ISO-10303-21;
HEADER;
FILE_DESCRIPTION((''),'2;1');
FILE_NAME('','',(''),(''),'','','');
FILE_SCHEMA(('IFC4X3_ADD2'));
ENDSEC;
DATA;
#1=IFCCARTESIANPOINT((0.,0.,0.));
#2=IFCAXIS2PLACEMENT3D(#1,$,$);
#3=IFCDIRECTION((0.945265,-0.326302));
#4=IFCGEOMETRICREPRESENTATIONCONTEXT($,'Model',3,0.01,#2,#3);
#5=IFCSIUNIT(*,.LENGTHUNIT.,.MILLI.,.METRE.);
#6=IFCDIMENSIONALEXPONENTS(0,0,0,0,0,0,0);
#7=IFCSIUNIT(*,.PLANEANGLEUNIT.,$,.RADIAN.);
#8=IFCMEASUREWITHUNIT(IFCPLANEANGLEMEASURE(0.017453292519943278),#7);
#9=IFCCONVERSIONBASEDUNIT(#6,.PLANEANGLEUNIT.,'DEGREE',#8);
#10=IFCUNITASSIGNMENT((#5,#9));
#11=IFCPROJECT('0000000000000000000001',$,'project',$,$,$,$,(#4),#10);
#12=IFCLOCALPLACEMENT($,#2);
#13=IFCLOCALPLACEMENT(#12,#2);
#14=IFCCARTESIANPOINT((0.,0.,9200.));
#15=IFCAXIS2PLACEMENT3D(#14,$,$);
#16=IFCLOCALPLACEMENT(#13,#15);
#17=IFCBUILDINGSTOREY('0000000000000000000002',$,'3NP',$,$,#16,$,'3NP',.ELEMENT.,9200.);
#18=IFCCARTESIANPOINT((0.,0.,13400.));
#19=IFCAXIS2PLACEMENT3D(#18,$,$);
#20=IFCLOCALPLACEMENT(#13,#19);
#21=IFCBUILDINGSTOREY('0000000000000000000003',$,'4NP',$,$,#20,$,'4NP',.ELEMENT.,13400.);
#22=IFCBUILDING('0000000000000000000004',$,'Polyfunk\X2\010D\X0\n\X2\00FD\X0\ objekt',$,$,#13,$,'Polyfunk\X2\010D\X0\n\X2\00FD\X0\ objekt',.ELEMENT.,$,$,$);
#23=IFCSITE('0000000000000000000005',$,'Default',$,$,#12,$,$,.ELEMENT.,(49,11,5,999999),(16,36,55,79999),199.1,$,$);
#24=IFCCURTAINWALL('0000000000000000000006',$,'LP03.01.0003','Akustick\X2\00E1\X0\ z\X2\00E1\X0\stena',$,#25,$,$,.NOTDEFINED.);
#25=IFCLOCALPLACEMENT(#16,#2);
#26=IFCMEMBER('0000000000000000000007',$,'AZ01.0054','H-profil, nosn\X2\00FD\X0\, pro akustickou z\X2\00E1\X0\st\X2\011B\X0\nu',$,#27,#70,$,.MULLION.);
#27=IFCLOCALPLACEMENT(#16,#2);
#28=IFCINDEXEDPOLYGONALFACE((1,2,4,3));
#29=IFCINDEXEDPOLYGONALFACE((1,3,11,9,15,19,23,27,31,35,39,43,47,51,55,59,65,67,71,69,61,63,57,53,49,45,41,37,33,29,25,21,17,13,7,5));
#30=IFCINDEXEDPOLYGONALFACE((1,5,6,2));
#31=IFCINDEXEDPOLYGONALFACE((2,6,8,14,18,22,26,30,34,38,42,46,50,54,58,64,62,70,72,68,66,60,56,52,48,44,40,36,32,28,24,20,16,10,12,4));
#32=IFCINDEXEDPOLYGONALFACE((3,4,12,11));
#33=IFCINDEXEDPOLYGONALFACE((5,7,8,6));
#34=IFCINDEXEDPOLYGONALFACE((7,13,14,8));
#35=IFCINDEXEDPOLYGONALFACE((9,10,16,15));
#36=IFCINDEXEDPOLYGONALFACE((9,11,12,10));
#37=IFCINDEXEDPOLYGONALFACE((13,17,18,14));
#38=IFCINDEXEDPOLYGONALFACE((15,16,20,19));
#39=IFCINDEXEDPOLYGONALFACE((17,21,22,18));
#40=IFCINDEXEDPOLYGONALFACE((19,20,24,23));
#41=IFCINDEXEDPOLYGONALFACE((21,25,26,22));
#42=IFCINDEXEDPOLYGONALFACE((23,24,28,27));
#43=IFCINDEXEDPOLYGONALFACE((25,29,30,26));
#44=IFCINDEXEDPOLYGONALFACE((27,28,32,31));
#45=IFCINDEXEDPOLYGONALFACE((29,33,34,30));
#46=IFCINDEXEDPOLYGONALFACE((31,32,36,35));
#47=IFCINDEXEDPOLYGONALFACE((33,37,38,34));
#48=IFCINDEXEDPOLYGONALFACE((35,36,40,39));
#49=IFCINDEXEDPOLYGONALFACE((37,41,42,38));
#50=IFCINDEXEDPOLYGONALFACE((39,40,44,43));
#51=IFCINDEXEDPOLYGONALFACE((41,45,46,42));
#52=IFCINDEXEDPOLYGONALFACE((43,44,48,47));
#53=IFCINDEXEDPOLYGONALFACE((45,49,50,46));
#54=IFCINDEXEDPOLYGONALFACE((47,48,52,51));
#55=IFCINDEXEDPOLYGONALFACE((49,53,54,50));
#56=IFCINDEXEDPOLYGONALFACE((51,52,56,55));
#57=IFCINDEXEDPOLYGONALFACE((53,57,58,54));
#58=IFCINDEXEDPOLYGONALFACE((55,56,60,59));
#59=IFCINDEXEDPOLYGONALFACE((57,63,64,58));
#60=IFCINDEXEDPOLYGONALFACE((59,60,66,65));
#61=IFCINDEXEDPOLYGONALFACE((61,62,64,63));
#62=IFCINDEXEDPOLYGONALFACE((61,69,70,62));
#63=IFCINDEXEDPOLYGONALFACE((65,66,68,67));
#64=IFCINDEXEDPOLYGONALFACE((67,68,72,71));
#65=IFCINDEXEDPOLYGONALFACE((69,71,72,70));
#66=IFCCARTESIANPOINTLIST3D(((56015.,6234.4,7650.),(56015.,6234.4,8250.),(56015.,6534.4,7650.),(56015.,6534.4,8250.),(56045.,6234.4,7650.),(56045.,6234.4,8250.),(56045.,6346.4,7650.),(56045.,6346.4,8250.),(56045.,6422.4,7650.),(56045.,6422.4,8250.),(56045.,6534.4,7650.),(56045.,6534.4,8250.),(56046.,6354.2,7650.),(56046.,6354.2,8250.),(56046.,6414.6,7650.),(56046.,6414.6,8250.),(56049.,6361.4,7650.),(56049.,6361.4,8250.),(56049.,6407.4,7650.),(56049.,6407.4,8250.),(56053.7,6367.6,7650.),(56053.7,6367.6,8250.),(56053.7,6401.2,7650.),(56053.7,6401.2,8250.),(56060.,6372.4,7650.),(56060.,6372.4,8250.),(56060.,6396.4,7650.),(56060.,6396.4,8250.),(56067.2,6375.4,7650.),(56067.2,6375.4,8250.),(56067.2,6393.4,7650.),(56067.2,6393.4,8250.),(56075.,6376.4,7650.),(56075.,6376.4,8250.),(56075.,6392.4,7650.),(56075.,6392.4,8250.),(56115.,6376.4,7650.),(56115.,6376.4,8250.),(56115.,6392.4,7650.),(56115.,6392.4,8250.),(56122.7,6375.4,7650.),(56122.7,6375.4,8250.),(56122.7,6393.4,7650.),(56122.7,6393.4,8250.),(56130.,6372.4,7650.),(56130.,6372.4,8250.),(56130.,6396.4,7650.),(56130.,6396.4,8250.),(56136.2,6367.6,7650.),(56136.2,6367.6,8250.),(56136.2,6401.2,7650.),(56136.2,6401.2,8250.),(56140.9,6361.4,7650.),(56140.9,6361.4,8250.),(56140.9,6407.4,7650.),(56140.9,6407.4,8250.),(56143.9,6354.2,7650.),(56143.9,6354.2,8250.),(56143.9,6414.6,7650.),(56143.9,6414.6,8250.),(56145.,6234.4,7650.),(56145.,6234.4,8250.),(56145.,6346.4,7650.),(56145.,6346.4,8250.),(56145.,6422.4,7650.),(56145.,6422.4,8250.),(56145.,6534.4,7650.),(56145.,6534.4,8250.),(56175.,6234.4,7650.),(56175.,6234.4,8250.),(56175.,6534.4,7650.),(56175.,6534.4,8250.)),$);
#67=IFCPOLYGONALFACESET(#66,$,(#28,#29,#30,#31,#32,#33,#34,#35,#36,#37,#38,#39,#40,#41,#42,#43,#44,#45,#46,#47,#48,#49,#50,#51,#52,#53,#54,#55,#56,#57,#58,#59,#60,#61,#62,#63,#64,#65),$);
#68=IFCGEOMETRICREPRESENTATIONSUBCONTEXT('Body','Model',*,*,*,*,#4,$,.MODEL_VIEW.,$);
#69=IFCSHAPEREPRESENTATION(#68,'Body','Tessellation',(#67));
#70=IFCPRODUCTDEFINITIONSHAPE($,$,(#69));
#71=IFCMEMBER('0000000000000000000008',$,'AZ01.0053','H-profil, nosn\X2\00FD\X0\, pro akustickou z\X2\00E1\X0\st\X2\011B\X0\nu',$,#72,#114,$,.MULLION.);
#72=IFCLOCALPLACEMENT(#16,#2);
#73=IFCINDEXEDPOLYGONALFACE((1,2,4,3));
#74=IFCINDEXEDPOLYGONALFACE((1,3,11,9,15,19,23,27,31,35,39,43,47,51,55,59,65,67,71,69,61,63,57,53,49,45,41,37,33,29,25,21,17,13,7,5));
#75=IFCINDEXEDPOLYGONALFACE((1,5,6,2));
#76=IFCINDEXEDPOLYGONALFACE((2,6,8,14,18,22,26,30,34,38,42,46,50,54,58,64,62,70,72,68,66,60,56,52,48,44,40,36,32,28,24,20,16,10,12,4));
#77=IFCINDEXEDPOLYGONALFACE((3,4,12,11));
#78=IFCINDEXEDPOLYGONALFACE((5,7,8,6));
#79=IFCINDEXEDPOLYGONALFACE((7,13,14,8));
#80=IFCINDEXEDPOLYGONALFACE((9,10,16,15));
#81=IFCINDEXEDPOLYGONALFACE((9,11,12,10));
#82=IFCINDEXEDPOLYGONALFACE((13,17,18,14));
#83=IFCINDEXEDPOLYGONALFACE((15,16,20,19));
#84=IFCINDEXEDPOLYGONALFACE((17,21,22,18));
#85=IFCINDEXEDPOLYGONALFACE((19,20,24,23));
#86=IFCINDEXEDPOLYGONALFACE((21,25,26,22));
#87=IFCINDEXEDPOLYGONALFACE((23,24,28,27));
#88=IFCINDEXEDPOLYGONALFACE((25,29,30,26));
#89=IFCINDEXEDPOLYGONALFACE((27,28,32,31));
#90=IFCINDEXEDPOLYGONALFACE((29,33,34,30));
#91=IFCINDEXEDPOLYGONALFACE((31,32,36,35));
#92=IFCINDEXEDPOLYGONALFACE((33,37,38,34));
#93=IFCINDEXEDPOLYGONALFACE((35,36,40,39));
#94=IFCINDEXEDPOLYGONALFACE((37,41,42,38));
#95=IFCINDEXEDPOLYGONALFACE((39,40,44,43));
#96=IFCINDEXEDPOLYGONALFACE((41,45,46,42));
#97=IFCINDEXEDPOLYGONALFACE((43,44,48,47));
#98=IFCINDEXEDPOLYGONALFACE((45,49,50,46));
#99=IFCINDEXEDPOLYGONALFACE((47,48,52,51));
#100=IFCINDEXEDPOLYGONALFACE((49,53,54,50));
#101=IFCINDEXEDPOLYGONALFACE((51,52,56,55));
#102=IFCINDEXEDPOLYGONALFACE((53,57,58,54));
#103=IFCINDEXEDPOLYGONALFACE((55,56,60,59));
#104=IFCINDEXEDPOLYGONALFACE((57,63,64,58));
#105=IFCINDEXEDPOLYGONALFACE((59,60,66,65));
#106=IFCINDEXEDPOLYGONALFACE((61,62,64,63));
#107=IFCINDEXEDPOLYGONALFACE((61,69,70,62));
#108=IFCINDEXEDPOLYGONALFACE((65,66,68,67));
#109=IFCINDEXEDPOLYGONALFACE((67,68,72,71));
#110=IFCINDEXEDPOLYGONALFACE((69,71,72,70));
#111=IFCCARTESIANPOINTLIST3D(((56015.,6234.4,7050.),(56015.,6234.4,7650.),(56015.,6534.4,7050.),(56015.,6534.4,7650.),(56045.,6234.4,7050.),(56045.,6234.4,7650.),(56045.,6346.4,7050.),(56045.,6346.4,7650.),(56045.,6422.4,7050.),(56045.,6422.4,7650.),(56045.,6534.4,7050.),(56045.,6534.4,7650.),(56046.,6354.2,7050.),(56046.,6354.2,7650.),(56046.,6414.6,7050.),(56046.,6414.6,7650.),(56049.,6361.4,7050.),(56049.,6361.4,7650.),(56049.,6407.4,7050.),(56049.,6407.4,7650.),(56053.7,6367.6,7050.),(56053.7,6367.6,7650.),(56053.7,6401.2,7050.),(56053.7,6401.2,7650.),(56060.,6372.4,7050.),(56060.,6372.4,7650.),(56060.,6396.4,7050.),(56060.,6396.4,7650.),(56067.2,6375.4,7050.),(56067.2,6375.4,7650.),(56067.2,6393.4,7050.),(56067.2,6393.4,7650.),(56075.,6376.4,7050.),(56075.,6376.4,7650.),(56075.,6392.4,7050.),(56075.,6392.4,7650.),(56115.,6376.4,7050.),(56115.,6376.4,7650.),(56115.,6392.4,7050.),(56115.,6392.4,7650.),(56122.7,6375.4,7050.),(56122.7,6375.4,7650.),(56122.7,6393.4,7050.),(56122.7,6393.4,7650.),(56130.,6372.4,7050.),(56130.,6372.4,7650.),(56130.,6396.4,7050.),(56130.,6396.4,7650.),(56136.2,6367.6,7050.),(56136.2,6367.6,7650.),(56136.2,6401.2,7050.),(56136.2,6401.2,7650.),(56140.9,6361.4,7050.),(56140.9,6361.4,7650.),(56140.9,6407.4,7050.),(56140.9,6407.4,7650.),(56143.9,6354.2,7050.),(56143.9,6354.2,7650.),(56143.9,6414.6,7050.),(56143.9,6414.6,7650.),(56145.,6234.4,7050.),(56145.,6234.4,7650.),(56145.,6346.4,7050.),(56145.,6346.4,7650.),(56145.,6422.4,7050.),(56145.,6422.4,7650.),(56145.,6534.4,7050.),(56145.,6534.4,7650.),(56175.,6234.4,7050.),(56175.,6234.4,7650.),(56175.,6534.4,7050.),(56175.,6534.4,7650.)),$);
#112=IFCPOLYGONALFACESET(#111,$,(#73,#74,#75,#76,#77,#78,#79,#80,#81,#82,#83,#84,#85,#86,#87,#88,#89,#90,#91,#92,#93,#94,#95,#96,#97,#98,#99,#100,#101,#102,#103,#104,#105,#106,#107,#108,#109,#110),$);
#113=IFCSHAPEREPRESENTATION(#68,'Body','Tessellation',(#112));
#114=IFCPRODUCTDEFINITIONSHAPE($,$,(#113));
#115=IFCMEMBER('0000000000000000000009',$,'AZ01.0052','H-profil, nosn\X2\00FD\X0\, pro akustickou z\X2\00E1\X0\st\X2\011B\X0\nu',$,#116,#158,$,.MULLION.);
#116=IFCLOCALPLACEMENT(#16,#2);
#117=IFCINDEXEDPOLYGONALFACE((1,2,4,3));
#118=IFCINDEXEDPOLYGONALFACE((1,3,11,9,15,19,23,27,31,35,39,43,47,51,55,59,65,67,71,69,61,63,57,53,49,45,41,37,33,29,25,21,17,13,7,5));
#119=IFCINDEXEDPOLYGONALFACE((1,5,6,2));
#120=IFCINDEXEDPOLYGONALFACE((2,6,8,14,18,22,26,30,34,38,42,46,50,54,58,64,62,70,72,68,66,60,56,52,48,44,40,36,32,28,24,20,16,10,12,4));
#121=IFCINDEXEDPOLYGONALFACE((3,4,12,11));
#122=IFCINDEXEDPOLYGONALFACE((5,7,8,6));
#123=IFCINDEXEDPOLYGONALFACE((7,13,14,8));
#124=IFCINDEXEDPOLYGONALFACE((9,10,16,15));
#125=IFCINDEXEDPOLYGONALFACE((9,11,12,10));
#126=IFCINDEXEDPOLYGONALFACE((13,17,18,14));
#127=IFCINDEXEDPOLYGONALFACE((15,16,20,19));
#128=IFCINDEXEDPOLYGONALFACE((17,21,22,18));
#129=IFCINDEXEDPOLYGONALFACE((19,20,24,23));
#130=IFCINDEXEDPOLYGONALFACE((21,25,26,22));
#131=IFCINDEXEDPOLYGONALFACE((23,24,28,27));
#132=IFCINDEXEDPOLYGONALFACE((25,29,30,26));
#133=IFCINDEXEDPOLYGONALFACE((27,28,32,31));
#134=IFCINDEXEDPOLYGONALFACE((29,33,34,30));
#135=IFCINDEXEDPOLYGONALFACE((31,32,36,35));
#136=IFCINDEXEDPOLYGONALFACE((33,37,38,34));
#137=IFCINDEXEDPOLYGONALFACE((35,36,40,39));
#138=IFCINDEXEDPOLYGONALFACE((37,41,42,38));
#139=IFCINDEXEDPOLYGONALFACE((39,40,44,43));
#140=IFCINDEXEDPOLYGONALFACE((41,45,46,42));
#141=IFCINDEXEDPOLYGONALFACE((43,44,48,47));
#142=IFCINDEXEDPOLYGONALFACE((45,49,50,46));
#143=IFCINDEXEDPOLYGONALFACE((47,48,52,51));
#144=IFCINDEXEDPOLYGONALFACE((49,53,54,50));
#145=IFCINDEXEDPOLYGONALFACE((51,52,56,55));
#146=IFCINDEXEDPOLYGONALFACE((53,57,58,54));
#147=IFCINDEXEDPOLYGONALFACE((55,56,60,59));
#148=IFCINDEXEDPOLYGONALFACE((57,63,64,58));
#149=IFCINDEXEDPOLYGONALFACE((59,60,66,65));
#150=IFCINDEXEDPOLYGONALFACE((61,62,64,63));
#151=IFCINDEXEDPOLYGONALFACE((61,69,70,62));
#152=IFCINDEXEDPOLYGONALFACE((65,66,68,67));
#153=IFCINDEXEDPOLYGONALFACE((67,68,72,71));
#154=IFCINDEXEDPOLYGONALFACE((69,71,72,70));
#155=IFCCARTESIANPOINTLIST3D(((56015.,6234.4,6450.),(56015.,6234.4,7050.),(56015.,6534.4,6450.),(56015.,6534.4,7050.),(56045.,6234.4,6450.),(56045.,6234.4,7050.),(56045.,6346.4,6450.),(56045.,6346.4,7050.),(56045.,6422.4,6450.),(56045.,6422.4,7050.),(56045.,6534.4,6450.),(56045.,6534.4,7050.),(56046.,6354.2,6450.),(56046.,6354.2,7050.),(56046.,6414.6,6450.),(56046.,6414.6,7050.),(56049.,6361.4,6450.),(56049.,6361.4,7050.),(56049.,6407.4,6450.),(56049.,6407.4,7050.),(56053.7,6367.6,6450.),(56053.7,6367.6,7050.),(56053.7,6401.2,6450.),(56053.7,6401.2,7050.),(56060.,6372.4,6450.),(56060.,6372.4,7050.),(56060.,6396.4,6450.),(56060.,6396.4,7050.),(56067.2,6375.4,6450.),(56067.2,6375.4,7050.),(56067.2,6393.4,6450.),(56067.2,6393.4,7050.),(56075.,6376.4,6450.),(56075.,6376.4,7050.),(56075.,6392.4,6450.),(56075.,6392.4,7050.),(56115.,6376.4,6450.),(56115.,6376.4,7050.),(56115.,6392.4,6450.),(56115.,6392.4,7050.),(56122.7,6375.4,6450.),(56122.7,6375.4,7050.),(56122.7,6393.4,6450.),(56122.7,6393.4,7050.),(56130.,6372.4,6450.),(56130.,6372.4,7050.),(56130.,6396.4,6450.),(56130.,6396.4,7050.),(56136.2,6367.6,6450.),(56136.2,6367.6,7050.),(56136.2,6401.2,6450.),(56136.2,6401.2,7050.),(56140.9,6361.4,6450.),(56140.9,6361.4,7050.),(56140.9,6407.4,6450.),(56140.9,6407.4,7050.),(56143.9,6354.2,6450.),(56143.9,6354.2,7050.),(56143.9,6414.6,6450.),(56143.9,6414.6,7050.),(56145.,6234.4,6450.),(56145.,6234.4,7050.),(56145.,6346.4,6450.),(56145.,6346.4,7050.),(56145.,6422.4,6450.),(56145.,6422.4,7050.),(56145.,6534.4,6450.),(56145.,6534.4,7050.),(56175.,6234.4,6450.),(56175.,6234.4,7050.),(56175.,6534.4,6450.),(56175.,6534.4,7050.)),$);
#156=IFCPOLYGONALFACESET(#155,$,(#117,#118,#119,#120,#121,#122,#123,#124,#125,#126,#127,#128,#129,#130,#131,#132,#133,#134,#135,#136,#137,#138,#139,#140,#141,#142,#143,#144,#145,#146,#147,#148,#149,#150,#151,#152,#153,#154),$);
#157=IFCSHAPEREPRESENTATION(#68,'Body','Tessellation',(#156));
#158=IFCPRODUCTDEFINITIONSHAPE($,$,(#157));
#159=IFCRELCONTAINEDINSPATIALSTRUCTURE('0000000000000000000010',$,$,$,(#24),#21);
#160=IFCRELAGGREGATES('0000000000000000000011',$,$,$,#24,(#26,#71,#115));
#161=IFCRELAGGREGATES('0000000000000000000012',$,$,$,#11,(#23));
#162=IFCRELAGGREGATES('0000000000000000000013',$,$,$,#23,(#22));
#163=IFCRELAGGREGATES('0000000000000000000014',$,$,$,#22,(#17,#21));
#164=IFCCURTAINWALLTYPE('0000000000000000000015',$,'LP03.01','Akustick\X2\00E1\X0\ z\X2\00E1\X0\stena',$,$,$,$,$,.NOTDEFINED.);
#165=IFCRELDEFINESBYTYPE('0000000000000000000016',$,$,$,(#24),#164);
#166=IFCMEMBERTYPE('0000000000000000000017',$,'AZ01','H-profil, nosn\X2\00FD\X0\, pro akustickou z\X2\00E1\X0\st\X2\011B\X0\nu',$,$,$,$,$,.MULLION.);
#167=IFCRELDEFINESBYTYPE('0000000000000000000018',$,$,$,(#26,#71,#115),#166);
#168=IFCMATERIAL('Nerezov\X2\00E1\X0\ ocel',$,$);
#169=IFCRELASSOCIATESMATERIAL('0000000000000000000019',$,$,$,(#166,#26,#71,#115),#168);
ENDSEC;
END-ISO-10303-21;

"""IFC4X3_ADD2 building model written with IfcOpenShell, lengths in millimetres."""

from ifc_helpers import new_model, entity, si_unit, converted_unit, direction, frame, frame_2d, origin, place, context, subcontext, project, spatial, polyline, circle_curve, parameter, trimmed, segment, composite_curve, outline, extrude, source, transform, mapped, material, material_profile, profile_set, profile_usage, type_object, element, aggregate, save


model = new_model("IFC4X3_ADD2")

# Units and contexts
model_context = context("Model", 3, precision=0.01, world=origin(), true_north=direction((0.945265, -0.326302)))
body_context = subcontext(model_context, "Body", "Model", "MODEL_VIEW")
ifc_project = project(units=[si_unit("LENGTHUNIT", "METRE", prefix="MILLI"), converted_unit("PLANEANGLEUNIT", "DEGREE", entity("IfcPlaneAngleMeasure", 0.017453292519943278), si_unit("PLANEANGLEUNIT", "RADIAN"), dimensions=[0, 0, 0, 0, 0, 0, 0])], contexts=[model_context])

# Site, building, storey
site_placement = place(None, origin())
site = spatial("IfcSite", under=ifc_project, at=site_placement, Name="Default", CompositionType="ELEMENT", RefLatitude=(49, 11, 5, 999999), RefLongitude=(16, 36, 55, 79999), RefElevation=199.1)
building_placement = place(site_placement, origin())
building = spatial("IfcBuilding", under=site, at=building_placement, Name="Polyfunkčný objekt", LongName="Polyfunkčný objekt", CompositionType="ELEMENT")
storey_1_placement = place(building_placement, frame((0.0, 0.0, 9200.0)))
storey_1 = spatial("IfcBuildingStorey", under=building, at=storey_1_placement, Name="3NP", LongName="3NP", CompositionType="ELEMENT", Elevation=9200.0)

# Shared definitions
storey_2_placement = place(building_placement, frame((0.0, 0.0, 13400.0)))
storey_2 = spatial("IfcBuildingStorey", under=building, at=storey_2_placement, Name="4NP", LongName="4NP", CompositionType="ELEMENT", Elevation=13400.0)

# Shared definitions
curtain_wall_type_1 = type_object("IfcCurtainWallType", Name="LP03.01", Description="Akustická zástena", PredefinedType="NOTDEFINED")
ifc_material_1 = material(Name="Nerezová ocel")
ifc_material_profile_1 = material_profile(ifc_material_1, outline(composite_curve([segment(polyline([(50.0, -150.0), (80.0, -150.0)]), True, "CONTINUOUS"), segment(polyline([(80.0, -150.0), (80.0, 150.0)]), True, "CONTINUOUS"), segment(polyline([(80.0, 150.0), (50.0, 150.0)]), True, "CONTINUOUS"), segment(polyline([(50.0, 150.0), (50.0, 38.0)]), True, "CONTINUOUS"), segment(trimmed(circle_curve(frame_2d((20.0, 38.0), x_axis=(0.0, 1.0)), 30.0), [parameter(180.0)], [parameter(270.0)], True, "PARAMETER"), False, "CONTINUOUS"), segment(polyline([(20.0, 8.0), (-20.0, 8.0)]), True, "CONTINUOUS"), segment(trimmed(circle_curve(frame_2d((-20.0, 38.0), x_axis=(0.0, 1.0)), 30.0), [parameter(90.0)], [parameter(180.0)], True, "PARAMETER"), False, "CONTINUOUS"), segment(polyline([(-50.0, 38.0), (-50.0, 150.0)]), True, "CONTINUOUS"), segment(polyline([(-50.0, 150.0), (-80.0, 150.0)]), True, "CONTINUOUS"), segment(polyline([(-80.0, 150.0), (-80.0, -150.0)]), True, "CONTINUOUS"), segment(polyline([(-80.0, -150.0), (-50.0, -150.0)]), True, "CONTINUOUS"), segment(polyline([(-50.0, -150.0), (-50.0, -38.0)]), True, "CONTINUOUS"), segment(trimmed(circle_curve(frame_2d((-20.0, -38.0), x_axis=(0.0, 1.0)), 30.0), [parameter(0.0)], [parameter(90.0)], True, "PARAMETER"), False, "CONTINUOUS"), segment(polyline([(-20.0, -8.0), (20.0, -8.0)]), True, "CONTINUOUS"), segment(trimmed(circle_curve(frame_2d((20.0, -38.0), x_axis=(0.0, 1.0)), 30.0), [parameter(270.0)], [parameter(0.0)], True, "PARAMETER"), False, "CONTINUOUS"), segment(polyline([(50.0, -38.0), (50.0, -150.0)]), True, "CONTINUOUS")], self_intersect=False)), Name="Profil zástena")
ifc_profile_set_1 = profile_set([ifc_material_profile_1], Name="Profil zástena")
ifc_profile_usage_1 = profile_usage(ifc_profile_set_1)
member_type_1 = type_object("IfcMemberType", Name="AZ01", Description="H-profil, nosný, pro akustickou zástěnu", PredefinedType="MULLION", material=ifc_profile_set_1)

# Curtain wall, members
curtain_wall_1_placement = place(storey_2_placement, frame((0.0, 0.0, -13400.0)))
curtain_wall_1 = element("IfcCurtainWall", 1, at=curtain_wall_1_placement, inside=storey_2, type_object=curtain_wall_type_1, Name="LP03.01.0003", Description="Akustická zástena", PredefinedType="NOTDEFINED")
shared_shape_1 = source(origin(), body_context, "Body", "SweptSolid", [
    extrude(outline(composite_curve([segment(polyline([(-150.0, -50.0), (-150.0, -80.0)]), True, "CONTINUOUS"), segment(polyline([(-150.0, -80.0), (150.0, -80.0)]), True, "CONTINUOUS"), segment(polyline([(150.0, -80.0), (150.0, -50.0)]), True, "CONTINUOUS"), segment(polyline([(150.0, -50.0), (38.0, -50.0)]), True, "CONTINUOUS"), segment(trimmed(circle_curve(frame_2d((38.0, -20.0), x_axis=(1.0, 0.0)), 30.0), [parameter(180.0)], [parameter(270.0)], True, "PARAMETER"), False, "CONTINUOUS"), segment(polyline([(8.0, -20.0), (8.0, 20.0)]), True, "CONTINUOUS"), segment(trimmed(circle_curve(frame_2d((38.0, 20.0), x_axis=(1.0, 0.0)), 30.0), [parameter(90.0)], [parameter(180.0)], True, "PARAMETER"), False, "CONTINUOUS"), segment(polyline([(38.0, 50.0), (150.0, 50.0)]), True, "CONTINUOUS"), segment(polyline([(150.0, 50.0), (150.0, 80.0)]), True, "CONTINUOUS"), segment(polyline([(150.0, 80.0), (-150.0, 80.0)]), True, "CONTINUOUS"), segment(polyline([(-150.0, 80.0), (-150.0, 50.0)]), True, "CONTINUOUS"), segment(polyline([(-150.0, 50.0), (-38.0, 50.0)]), True, "CONTINUOUS"), segment(trimmed(circle_curve(frame_2d((-38.0, 20.0), x_axis=(1.0, 0.0)), 30.0), [parameter(0.0)], [parameter(90.0)], True, "PARAMETER"), False, "CONTINUOUS"), segment(polyline([(-8.0, 20.0), (-8.0, -20.0)]), True, "CONTINUOUS"), segment(trimmed(circle_curve(frame_2d((-38.0, -20.0), x_axis=(1.0, 0.0)), 30.0), [parameter(270.0)], [parameter(0.0)], True, "PARAMETER"), False, "CONTINUOUS"), segment(polyline([(-38.0, -50.0), (-150.0, -50.0)]), True, "CONTINUOUS")], self_intersect=False)), frame((-150.0, 0.0, -600.0), z_axis=(0.0, 0.0, -1.0), x_axis=(1.0, 0.0, 0.0)), (0.0, 0.0, -1.0), 600.0),
])
member_1_placement = place(curtain_wall_1_placement, frame((56095.0, 6534.4, 16850.0), z_axis=(0.0, 0.0, -1.0), x_axis=(0.0, 1.0, 0.0)))
member_1 = element("IfcMember", 2, at=member_1_placement, type_object=member_type_1, material=ifc_profile_usage_1, Name="AZ01.0054", Description="H-profil, nosný, pro akustickou zástěnu", PredefinedType="MULLION", context=body_context, shape_type="MappedRepresentation", body=[
    mapped(shared_shape_1, transform((0.0, 0.0, 0.0), scale=1.0)),
])
member_2_placement = place(curtain_wall_1_placement, frame((56095.0, 6534.4, 16250.0), z_axis=(0.0, 0.0, -1.0), x_axis=(0.0, 1.0, 0.0)))
member_2 = element("IfcMember", 3, at=member_2_placement, type_object=member_type_1, material=ifc_profile_usage_1, Name="AZ01.0053", Description="H-profil, nosný, pro akustickou zástěnu", PredefinedType="MULLION", context=body_context, shape_type="MappedRepresentation", body=[
    mapped(shared_shape_1, transform((0.0, 0.0, 0.0), scale=1.0)),
])
member_3_placement = place(curtain_wall_1_placement, frame((56095.0, 6534.4, 15650.0), z_axis=(0.0, 0.0, -1.0), x_axis=(0.0, 1.0, 0.0)))
member_3 = element("IfcMember", 4, at=member_3_placement, type_object=member_type_1, material=ifc_profile_usage_1, Name="AZ01.0052", Description="H-profil, nosný, pro akustickou zástěnu", PredefinedType="MULLION", context=body_context, shape_type="MappedRepresentation", body=[
    mapped(shared_shape_1, transform((0.0, 0.0, 0.0), scale=1.0)),
])
aggregate(curtain_wall_1, [member_1, member_2, member_3])

save(model, "model.ifc")
